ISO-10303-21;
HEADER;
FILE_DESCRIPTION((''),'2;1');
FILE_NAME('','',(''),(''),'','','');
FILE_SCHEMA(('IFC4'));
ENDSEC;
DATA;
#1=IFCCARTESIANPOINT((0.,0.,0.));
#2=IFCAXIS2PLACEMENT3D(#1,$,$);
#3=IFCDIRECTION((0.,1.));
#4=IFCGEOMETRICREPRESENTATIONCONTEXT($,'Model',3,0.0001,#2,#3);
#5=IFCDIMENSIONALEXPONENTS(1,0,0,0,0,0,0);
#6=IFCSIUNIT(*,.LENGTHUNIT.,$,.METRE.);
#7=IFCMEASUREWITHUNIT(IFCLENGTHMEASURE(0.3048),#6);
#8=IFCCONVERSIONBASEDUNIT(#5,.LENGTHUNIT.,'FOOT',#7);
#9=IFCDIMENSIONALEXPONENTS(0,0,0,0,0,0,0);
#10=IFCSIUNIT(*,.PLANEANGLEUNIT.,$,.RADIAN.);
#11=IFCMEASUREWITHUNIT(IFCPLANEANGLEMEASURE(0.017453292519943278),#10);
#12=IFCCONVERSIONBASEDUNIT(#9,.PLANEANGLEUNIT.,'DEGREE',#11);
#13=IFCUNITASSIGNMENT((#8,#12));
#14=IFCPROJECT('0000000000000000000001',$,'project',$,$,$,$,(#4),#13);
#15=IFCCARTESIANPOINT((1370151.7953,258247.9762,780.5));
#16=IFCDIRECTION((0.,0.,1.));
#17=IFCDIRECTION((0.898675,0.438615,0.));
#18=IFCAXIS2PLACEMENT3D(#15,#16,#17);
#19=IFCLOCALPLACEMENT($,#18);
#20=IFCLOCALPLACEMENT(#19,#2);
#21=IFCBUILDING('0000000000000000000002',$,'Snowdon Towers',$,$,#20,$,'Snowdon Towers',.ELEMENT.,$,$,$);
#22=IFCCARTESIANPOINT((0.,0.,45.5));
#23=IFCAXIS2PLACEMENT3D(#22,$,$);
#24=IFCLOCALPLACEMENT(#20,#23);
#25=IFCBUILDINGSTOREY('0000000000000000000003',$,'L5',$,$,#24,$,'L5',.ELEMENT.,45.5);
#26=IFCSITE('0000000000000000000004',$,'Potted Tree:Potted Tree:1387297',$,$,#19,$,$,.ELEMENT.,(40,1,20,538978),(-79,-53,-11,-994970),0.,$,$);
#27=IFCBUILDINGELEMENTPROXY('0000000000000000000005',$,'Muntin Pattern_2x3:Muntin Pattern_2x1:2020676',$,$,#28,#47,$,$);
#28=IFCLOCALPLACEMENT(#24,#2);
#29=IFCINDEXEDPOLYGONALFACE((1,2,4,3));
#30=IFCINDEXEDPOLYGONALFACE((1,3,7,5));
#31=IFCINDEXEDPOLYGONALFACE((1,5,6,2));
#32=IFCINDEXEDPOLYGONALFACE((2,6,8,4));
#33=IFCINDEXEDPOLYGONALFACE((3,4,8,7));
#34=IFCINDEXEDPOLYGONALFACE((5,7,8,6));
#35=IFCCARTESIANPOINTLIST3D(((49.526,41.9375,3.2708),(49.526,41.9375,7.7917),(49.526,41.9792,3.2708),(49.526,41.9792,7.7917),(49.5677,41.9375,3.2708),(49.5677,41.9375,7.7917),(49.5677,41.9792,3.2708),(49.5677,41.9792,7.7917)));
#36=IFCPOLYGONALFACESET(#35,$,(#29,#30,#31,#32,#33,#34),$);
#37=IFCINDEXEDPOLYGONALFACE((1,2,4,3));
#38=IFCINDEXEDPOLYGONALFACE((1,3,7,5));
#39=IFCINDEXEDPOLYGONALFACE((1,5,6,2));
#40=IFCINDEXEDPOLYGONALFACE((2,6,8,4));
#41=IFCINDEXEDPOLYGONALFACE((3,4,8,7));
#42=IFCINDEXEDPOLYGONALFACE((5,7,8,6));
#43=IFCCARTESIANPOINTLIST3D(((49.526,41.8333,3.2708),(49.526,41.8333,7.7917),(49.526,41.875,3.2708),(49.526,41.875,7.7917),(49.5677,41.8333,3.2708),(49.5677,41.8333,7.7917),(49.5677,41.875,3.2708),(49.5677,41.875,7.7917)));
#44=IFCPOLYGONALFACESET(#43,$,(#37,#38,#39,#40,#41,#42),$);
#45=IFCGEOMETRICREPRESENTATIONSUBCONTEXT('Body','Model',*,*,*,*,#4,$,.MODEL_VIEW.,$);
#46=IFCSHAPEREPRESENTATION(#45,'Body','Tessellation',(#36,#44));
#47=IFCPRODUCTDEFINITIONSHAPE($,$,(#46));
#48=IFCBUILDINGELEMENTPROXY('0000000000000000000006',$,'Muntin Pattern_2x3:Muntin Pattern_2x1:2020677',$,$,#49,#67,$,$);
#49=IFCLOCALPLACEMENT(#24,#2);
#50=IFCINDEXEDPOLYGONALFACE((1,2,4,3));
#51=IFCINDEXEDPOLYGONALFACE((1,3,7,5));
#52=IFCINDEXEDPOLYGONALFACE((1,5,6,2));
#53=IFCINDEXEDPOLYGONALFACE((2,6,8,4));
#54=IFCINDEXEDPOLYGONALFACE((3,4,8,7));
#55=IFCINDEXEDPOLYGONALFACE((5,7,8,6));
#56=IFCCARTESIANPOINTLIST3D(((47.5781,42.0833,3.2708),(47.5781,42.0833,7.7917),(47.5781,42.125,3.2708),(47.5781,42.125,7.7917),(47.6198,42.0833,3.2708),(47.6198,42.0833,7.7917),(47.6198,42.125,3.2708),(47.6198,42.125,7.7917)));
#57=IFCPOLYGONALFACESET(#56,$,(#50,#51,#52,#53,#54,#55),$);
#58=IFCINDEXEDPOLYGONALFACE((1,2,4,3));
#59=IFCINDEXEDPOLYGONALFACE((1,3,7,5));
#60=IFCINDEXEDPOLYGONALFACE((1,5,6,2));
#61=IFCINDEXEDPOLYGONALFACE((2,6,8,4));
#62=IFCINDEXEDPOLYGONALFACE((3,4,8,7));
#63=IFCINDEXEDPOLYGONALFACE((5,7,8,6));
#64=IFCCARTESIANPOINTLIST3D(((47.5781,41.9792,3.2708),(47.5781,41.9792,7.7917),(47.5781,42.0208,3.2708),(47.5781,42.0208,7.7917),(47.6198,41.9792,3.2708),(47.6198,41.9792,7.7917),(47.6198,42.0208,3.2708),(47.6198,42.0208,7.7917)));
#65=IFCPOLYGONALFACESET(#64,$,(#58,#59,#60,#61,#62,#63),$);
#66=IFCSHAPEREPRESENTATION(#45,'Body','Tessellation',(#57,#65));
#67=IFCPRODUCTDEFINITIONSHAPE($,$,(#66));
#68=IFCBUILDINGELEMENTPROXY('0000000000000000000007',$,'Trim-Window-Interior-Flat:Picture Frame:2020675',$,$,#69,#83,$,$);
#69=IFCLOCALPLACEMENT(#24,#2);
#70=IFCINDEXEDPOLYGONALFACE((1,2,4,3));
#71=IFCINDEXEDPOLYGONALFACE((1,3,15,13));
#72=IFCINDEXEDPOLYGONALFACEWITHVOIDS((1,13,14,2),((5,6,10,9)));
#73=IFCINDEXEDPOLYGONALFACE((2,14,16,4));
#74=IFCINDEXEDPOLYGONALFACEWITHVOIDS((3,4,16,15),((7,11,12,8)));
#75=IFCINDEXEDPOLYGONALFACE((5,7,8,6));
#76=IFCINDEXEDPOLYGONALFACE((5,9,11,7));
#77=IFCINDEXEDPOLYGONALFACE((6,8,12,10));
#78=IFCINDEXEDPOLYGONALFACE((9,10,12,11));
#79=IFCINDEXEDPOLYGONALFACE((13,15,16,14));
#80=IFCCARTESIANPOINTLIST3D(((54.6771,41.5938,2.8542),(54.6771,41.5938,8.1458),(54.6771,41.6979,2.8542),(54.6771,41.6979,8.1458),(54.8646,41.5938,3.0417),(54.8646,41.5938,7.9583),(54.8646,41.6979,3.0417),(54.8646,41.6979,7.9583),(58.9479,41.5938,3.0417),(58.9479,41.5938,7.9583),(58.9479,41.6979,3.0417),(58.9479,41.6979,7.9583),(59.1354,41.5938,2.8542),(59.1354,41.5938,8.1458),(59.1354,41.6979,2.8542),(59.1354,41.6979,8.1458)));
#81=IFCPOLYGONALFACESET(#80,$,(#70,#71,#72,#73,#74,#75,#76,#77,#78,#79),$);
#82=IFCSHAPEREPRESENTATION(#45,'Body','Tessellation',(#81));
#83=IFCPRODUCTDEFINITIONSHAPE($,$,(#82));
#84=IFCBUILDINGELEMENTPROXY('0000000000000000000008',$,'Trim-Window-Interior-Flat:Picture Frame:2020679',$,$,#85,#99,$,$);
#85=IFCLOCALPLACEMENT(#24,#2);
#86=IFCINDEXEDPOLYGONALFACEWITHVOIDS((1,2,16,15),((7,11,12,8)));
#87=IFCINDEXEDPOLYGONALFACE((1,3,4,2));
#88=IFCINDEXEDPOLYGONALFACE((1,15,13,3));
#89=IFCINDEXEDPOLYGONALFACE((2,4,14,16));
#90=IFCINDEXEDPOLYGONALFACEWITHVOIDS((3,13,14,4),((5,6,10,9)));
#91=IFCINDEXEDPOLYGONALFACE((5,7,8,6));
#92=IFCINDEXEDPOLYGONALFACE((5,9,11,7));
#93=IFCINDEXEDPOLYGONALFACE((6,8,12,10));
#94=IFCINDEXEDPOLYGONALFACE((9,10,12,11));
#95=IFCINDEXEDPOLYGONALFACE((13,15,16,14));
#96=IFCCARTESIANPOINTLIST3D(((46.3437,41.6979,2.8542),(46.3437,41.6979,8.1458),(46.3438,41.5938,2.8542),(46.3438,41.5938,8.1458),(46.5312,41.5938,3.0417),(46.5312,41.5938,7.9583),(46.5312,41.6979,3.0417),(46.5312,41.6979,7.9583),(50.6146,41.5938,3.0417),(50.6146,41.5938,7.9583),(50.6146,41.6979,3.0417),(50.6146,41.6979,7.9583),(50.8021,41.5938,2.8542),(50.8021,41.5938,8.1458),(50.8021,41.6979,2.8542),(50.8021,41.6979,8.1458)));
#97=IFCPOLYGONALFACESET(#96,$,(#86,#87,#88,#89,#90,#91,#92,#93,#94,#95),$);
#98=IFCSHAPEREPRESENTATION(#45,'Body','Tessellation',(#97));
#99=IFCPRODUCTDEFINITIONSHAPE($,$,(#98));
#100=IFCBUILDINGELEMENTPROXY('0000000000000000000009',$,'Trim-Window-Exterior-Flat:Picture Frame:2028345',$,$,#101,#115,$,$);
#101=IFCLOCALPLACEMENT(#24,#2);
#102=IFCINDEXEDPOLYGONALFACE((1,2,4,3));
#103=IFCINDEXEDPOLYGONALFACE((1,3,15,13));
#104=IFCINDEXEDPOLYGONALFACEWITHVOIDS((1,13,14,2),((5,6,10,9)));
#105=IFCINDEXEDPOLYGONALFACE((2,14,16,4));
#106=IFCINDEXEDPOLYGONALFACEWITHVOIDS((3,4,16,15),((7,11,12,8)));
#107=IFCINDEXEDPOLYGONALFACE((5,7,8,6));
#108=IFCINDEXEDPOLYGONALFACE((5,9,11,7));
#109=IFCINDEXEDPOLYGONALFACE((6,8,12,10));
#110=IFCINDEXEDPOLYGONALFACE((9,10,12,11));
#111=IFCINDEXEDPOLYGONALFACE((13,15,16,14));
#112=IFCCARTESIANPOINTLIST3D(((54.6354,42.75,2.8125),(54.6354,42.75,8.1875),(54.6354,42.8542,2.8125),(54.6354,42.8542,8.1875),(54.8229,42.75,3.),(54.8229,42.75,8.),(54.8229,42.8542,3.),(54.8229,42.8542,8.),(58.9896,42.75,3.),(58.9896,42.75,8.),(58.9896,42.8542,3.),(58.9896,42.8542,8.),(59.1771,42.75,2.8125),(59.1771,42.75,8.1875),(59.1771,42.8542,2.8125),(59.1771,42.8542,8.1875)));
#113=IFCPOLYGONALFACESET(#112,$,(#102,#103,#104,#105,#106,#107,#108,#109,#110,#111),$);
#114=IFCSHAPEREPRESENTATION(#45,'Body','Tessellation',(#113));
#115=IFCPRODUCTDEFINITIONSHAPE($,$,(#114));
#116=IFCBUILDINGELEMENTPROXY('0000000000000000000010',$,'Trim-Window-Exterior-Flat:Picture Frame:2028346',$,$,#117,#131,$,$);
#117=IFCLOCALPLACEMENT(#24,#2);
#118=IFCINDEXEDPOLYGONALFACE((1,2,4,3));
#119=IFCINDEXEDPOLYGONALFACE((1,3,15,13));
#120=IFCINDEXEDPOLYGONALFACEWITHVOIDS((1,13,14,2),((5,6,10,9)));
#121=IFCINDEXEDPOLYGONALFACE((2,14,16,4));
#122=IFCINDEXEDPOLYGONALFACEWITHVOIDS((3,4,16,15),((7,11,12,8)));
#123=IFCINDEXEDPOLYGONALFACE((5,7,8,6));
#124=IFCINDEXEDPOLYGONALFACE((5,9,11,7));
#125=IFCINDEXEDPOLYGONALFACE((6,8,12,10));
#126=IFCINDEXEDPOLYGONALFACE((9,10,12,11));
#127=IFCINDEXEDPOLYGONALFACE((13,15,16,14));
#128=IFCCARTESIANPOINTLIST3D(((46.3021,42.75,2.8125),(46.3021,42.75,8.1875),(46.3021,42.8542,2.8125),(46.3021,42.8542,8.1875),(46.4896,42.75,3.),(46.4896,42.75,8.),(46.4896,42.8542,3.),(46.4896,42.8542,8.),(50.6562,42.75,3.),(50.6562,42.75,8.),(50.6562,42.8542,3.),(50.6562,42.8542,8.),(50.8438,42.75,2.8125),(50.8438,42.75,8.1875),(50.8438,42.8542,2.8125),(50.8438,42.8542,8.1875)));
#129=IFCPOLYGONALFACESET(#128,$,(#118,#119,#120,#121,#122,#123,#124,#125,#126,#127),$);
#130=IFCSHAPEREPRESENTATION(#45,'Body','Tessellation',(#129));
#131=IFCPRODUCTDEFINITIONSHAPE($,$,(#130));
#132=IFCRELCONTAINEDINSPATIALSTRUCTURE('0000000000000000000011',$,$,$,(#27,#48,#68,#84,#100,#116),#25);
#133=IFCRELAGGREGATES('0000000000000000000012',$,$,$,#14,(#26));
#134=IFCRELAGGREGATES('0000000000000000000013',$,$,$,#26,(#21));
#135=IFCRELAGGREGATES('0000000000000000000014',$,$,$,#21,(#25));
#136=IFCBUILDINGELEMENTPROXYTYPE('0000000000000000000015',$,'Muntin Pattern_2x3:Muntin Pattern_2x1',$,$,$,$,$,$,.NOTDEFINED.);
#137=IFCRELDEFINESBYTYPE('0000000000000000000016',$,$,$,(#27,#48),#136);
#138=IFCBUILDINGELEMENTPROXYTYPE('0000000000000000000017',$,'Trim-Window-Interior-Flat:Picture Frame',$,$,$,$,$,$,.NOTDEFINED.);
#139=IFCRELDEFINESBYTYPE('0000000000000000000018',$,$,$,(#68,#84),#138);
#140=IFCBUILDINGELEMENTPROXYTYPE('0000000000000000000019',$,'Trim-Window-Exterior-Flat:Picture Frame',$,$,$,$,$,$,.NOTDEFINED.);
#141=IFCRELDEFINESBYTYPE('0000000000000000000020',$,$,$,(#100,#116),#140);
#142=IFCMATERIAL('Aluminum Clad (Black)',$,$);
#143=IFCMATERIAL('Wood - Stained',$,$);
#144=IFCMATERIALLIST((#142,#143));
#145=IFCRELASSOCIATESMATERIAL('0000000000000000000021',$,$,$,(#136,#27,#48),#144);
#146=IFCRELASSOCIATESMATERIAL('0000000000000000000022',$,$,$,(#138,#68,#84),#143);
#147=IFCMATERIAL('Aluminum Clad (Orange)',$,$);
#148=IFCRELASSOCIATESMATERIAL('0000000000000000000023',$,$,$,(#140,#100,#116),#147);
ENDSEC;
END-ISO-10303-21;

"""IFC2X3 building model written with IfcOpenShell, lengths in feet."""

from ifc_helpers import new_model, entity, si_unit, converted_unit, direction, frame, frame_2d, origin, place, context, subcontext, project, spatial, polyline, rectangle, outline, extrude, source, transform, mapped, material, material_list, type_object, type_shapes, element, save


model = new_model("IFC2X3")

# Units and contexts
model_context = context("Model", 3, precision=0.0001, world=origin(), true_north=direction((0.0, 1.0)))
body_context = subcontext(model_context, "Body", "Model", "MODEL_VIEW")
ifc_project = project(units=[converted_unit("LENGTHUNIT", "FOOT", entity("IfcLengthMeasure", 0.3048), si_unit("LENGTHUNIT", "METRE"), dimensions=[1, 0, 0, 0, 0, 0, 0]), converted_unit("PLANEANGLEUNIT", "DEGREE", entity("IfcPlaneAngleMeasure", 0.017453292519943278), si_unit("PLANEANGLEUNIT", "RADIAN"), dimensions=[0, 0, 0, 0, 0, 0, 0])], contexts=[model_context])

# Site, building, storey
site_placement = place(None, frame((1370151.7953, 258247.9762, 780.5), z_axis=(0.0, 0.0, 1.0), x_axis=(0.898675, 0.438615, 0.0)))
site = spatial("IfcSite", under=ifc_project, at=site_placement, Name="Potted Tree:Potted Tree:1387297", CompositionType="ELEMENT", RefLatitude=(40, 1, 20, 538978), RefLongitude=(-79, -53, -11, -994970), RefElevation=0.0)
building_placement = place(site_placement, origin())
building = spatial("IfcBuilding", under=site, at=building_placement, Name="Snowdon Towers", LongName="Snowdon Towers", CompositionType="ELEMENT")
storey_placement = place(building_placement, frame((0.0, 0.0, 45.5)))
storey = spatial("IfcBuildingStorey", under=building, at=storey_placement, Name="L5", LongName="L5", CompositionType="ELEMENT", Elevation=45.5)

# Building element proxies
ifc_material_1 = material(Name="Aluminum Clad (Black)")
ifc_material_2 = material(Name="Wood - Stained")
ifc_material_list_1 = material_list([ifc_material_1, ifc_material_2])
building_element_proxy_type_1 = type_object("IfcBuildingElementProxyType", Name="Muntin Pattern_2x3:Muntin Pattern_2x1", PredefinedType="NOTDEFINED", material=ifc_material_list_1)
shared_shape_1 = source(origin(), body_context, "Body", "SweptSolid", [
    extrude(rectangle(XDim=0.0417, YDim=0.0417, at=frame_2d((0.0, 0.0), x_axis=(1.0, 0.0))), frame((0.0, 0.0521, 0.0), z_axis=(0.0, 0.0, 1.0), x_axis=(0.0, -1.0, 0.0)), (0.0, 0.0, 1.0), 4.5208),
    extrude(rectangle(XDim=0.0417, YDim=0.0417, at=frame_2d((0.0, 0.0), x_axis=(1.0, 0.0))), frame((0.0, -0.0521, 0.0), z_axis=(0.0, 0.0, 1.0), x_axis=(0.0, -1.0, 0.0)), (0.0, 0.0, 1.0), 4.5208),
])
type_shapes(building_element_proxy_type_1, [shared_shape_1])
for number, where, name in (
    (1, (49.5469, 41.9063, 3.2708), "Muntin Pattern_2x3:Muntin Pattern_2x1:2020676"),
    (2, (47.599, 42.0521, 3.2708), "Muntin Pattern_2x3:Muntin Pattern_2x1:2020677"),
):
    element("IfcBuildingElementProxy", number, at=place(storey_placement, frame(where)), inside=storey, type_object=building_element_proxy_type_1, material=ifc_material_list_1, Name=name, context=body_context, shape_type="MappedRepresentation", body=[
        mapped(shared_shape_1, transform((0.0, 0.0, 0.0), scale=1.0)),
    ])
building_element_proxy_type_2 = type_object("IfcBuildingElementProxyType", Name="Trim-Window-Interior-Flat:Picture Frame", PredefinedType="NOTDEFINED", material=ifc_material_2)
shared_shape_2 = source(origin(), body_context, "Body", "SweptSolid", [
    extrude(outline(polyline([(-2.2292, -2.6458), (2.2292, -2.6458), (2.2292, 2.6458), (-2.2292, 2.6458), (-2.2292, -2.6458)]), holes=[polyline([(-2.0417, -2.4583), (-2.0417, 2.4583), (2.0417, 2.4583), (2.0417, -2.4583), (-2.0417, -2.4583)])]), frame((0.0, -2.5, 0.0), z_axis=(0.0, 0.0, 1.0), x_axis=(-1.0, 0.0, 0.0)), (0.0, 0.0, 1.0), 0.1042),
])
type_shapes(building_element_proxy_type_2, [shared_shape_2])
for number, where, z_axis, x_axis, name in (
    (3, (56.9062, 41.6979, 8.0), (0.0, -1.0, 0.0), (1.0, 0.0, 0.0), "Trim-Window-Interior-Flat:Picture Frame:2020675"),
    (4, (48.5729, 41.6979, 8.0), (0.0, -1.0, 0.0), (1.0, 0.0, 0.0), "Trim-Window-Interior-Flat:Picture Frame:2020679"),
):
    element("IfcBuildingElementProxy", number, at=place(storey_placement, frame(where, z_axis=z_axis, x_axis=x_axis)), inside=storey, type_object=building_element_proxy_type_2, material=ifc_material_2, Name=name, context=body_context, shape_type="MappedRepresentation", body=[
        mapped(shared_shape_2, transform((0.0, 0.0, 0.0), scale=1.0)),
    ])
ifc_material_3 = material(Name="Aluminum Clad (Orange)")
building_element_proxy_type_3 = type_object("IfcBuildingElementProxyType", Name="Trim-Window-Exterior-Flat:Picture Frame", PredefinedType="NOTDEFINED", material=ifc_material_3)
shared_shape_3 = source(origin(), body_context, "Body", "SweptSolid", [
    extrude(outline(polyline([(-2.2708, -2.6875), (2.2708, -2.6875), (2.2708, 2.6875), (-2.2708, 2.6875), (-2.2708, -2.6875)]), holes=[polyline([(-2.0833, -2.5), (-2.0833, 2.5), (2.0833, 2.5), (2.0833, -2.5), (-2.0833, -2.5)])]), frame((0.0, -2.5, 0.0), z_axis=(0.0, 0.0, 1.0), x_axis=(-1.0, 0.0, 0.0)), (0.0, 0.0, 1.0), 0.1042),
])
type_shapes(building_element_proxy_type_3, [shared_shape_3])
for number, where, z_axis, x_axis, name in (
    (5, (56.9063, 42.75, 8.0), (0.0, 1.0, 0.0), (-1.0, 0.0, 0.0), "Trim-Window-Exterior-Flat:Picture Frame:2028345"),
    (6, (48.5729, 42.75, 8.0), (0.0, 1.0, 0.0), (-1.0, 0.0, 0.0), "Trim-Window-Exterior-Flat:Picture Frame:2028346"),
):
    element("IfcBuildingElementProxy", number, at=place(storey_placement, frame(where, z_axis=z_axis, x_axis=x_axis)), inside=storey, type_object=building_element_proxy_type_3, material=ifc_material_3, Name=name, context=body_context, shape_type="MappedRepresentation", body=[
        mapped(shared_shape_3, transform((0.0, 0.0, 0.0), scale=1.0)),
    ])

save(model, "model.ifc")
